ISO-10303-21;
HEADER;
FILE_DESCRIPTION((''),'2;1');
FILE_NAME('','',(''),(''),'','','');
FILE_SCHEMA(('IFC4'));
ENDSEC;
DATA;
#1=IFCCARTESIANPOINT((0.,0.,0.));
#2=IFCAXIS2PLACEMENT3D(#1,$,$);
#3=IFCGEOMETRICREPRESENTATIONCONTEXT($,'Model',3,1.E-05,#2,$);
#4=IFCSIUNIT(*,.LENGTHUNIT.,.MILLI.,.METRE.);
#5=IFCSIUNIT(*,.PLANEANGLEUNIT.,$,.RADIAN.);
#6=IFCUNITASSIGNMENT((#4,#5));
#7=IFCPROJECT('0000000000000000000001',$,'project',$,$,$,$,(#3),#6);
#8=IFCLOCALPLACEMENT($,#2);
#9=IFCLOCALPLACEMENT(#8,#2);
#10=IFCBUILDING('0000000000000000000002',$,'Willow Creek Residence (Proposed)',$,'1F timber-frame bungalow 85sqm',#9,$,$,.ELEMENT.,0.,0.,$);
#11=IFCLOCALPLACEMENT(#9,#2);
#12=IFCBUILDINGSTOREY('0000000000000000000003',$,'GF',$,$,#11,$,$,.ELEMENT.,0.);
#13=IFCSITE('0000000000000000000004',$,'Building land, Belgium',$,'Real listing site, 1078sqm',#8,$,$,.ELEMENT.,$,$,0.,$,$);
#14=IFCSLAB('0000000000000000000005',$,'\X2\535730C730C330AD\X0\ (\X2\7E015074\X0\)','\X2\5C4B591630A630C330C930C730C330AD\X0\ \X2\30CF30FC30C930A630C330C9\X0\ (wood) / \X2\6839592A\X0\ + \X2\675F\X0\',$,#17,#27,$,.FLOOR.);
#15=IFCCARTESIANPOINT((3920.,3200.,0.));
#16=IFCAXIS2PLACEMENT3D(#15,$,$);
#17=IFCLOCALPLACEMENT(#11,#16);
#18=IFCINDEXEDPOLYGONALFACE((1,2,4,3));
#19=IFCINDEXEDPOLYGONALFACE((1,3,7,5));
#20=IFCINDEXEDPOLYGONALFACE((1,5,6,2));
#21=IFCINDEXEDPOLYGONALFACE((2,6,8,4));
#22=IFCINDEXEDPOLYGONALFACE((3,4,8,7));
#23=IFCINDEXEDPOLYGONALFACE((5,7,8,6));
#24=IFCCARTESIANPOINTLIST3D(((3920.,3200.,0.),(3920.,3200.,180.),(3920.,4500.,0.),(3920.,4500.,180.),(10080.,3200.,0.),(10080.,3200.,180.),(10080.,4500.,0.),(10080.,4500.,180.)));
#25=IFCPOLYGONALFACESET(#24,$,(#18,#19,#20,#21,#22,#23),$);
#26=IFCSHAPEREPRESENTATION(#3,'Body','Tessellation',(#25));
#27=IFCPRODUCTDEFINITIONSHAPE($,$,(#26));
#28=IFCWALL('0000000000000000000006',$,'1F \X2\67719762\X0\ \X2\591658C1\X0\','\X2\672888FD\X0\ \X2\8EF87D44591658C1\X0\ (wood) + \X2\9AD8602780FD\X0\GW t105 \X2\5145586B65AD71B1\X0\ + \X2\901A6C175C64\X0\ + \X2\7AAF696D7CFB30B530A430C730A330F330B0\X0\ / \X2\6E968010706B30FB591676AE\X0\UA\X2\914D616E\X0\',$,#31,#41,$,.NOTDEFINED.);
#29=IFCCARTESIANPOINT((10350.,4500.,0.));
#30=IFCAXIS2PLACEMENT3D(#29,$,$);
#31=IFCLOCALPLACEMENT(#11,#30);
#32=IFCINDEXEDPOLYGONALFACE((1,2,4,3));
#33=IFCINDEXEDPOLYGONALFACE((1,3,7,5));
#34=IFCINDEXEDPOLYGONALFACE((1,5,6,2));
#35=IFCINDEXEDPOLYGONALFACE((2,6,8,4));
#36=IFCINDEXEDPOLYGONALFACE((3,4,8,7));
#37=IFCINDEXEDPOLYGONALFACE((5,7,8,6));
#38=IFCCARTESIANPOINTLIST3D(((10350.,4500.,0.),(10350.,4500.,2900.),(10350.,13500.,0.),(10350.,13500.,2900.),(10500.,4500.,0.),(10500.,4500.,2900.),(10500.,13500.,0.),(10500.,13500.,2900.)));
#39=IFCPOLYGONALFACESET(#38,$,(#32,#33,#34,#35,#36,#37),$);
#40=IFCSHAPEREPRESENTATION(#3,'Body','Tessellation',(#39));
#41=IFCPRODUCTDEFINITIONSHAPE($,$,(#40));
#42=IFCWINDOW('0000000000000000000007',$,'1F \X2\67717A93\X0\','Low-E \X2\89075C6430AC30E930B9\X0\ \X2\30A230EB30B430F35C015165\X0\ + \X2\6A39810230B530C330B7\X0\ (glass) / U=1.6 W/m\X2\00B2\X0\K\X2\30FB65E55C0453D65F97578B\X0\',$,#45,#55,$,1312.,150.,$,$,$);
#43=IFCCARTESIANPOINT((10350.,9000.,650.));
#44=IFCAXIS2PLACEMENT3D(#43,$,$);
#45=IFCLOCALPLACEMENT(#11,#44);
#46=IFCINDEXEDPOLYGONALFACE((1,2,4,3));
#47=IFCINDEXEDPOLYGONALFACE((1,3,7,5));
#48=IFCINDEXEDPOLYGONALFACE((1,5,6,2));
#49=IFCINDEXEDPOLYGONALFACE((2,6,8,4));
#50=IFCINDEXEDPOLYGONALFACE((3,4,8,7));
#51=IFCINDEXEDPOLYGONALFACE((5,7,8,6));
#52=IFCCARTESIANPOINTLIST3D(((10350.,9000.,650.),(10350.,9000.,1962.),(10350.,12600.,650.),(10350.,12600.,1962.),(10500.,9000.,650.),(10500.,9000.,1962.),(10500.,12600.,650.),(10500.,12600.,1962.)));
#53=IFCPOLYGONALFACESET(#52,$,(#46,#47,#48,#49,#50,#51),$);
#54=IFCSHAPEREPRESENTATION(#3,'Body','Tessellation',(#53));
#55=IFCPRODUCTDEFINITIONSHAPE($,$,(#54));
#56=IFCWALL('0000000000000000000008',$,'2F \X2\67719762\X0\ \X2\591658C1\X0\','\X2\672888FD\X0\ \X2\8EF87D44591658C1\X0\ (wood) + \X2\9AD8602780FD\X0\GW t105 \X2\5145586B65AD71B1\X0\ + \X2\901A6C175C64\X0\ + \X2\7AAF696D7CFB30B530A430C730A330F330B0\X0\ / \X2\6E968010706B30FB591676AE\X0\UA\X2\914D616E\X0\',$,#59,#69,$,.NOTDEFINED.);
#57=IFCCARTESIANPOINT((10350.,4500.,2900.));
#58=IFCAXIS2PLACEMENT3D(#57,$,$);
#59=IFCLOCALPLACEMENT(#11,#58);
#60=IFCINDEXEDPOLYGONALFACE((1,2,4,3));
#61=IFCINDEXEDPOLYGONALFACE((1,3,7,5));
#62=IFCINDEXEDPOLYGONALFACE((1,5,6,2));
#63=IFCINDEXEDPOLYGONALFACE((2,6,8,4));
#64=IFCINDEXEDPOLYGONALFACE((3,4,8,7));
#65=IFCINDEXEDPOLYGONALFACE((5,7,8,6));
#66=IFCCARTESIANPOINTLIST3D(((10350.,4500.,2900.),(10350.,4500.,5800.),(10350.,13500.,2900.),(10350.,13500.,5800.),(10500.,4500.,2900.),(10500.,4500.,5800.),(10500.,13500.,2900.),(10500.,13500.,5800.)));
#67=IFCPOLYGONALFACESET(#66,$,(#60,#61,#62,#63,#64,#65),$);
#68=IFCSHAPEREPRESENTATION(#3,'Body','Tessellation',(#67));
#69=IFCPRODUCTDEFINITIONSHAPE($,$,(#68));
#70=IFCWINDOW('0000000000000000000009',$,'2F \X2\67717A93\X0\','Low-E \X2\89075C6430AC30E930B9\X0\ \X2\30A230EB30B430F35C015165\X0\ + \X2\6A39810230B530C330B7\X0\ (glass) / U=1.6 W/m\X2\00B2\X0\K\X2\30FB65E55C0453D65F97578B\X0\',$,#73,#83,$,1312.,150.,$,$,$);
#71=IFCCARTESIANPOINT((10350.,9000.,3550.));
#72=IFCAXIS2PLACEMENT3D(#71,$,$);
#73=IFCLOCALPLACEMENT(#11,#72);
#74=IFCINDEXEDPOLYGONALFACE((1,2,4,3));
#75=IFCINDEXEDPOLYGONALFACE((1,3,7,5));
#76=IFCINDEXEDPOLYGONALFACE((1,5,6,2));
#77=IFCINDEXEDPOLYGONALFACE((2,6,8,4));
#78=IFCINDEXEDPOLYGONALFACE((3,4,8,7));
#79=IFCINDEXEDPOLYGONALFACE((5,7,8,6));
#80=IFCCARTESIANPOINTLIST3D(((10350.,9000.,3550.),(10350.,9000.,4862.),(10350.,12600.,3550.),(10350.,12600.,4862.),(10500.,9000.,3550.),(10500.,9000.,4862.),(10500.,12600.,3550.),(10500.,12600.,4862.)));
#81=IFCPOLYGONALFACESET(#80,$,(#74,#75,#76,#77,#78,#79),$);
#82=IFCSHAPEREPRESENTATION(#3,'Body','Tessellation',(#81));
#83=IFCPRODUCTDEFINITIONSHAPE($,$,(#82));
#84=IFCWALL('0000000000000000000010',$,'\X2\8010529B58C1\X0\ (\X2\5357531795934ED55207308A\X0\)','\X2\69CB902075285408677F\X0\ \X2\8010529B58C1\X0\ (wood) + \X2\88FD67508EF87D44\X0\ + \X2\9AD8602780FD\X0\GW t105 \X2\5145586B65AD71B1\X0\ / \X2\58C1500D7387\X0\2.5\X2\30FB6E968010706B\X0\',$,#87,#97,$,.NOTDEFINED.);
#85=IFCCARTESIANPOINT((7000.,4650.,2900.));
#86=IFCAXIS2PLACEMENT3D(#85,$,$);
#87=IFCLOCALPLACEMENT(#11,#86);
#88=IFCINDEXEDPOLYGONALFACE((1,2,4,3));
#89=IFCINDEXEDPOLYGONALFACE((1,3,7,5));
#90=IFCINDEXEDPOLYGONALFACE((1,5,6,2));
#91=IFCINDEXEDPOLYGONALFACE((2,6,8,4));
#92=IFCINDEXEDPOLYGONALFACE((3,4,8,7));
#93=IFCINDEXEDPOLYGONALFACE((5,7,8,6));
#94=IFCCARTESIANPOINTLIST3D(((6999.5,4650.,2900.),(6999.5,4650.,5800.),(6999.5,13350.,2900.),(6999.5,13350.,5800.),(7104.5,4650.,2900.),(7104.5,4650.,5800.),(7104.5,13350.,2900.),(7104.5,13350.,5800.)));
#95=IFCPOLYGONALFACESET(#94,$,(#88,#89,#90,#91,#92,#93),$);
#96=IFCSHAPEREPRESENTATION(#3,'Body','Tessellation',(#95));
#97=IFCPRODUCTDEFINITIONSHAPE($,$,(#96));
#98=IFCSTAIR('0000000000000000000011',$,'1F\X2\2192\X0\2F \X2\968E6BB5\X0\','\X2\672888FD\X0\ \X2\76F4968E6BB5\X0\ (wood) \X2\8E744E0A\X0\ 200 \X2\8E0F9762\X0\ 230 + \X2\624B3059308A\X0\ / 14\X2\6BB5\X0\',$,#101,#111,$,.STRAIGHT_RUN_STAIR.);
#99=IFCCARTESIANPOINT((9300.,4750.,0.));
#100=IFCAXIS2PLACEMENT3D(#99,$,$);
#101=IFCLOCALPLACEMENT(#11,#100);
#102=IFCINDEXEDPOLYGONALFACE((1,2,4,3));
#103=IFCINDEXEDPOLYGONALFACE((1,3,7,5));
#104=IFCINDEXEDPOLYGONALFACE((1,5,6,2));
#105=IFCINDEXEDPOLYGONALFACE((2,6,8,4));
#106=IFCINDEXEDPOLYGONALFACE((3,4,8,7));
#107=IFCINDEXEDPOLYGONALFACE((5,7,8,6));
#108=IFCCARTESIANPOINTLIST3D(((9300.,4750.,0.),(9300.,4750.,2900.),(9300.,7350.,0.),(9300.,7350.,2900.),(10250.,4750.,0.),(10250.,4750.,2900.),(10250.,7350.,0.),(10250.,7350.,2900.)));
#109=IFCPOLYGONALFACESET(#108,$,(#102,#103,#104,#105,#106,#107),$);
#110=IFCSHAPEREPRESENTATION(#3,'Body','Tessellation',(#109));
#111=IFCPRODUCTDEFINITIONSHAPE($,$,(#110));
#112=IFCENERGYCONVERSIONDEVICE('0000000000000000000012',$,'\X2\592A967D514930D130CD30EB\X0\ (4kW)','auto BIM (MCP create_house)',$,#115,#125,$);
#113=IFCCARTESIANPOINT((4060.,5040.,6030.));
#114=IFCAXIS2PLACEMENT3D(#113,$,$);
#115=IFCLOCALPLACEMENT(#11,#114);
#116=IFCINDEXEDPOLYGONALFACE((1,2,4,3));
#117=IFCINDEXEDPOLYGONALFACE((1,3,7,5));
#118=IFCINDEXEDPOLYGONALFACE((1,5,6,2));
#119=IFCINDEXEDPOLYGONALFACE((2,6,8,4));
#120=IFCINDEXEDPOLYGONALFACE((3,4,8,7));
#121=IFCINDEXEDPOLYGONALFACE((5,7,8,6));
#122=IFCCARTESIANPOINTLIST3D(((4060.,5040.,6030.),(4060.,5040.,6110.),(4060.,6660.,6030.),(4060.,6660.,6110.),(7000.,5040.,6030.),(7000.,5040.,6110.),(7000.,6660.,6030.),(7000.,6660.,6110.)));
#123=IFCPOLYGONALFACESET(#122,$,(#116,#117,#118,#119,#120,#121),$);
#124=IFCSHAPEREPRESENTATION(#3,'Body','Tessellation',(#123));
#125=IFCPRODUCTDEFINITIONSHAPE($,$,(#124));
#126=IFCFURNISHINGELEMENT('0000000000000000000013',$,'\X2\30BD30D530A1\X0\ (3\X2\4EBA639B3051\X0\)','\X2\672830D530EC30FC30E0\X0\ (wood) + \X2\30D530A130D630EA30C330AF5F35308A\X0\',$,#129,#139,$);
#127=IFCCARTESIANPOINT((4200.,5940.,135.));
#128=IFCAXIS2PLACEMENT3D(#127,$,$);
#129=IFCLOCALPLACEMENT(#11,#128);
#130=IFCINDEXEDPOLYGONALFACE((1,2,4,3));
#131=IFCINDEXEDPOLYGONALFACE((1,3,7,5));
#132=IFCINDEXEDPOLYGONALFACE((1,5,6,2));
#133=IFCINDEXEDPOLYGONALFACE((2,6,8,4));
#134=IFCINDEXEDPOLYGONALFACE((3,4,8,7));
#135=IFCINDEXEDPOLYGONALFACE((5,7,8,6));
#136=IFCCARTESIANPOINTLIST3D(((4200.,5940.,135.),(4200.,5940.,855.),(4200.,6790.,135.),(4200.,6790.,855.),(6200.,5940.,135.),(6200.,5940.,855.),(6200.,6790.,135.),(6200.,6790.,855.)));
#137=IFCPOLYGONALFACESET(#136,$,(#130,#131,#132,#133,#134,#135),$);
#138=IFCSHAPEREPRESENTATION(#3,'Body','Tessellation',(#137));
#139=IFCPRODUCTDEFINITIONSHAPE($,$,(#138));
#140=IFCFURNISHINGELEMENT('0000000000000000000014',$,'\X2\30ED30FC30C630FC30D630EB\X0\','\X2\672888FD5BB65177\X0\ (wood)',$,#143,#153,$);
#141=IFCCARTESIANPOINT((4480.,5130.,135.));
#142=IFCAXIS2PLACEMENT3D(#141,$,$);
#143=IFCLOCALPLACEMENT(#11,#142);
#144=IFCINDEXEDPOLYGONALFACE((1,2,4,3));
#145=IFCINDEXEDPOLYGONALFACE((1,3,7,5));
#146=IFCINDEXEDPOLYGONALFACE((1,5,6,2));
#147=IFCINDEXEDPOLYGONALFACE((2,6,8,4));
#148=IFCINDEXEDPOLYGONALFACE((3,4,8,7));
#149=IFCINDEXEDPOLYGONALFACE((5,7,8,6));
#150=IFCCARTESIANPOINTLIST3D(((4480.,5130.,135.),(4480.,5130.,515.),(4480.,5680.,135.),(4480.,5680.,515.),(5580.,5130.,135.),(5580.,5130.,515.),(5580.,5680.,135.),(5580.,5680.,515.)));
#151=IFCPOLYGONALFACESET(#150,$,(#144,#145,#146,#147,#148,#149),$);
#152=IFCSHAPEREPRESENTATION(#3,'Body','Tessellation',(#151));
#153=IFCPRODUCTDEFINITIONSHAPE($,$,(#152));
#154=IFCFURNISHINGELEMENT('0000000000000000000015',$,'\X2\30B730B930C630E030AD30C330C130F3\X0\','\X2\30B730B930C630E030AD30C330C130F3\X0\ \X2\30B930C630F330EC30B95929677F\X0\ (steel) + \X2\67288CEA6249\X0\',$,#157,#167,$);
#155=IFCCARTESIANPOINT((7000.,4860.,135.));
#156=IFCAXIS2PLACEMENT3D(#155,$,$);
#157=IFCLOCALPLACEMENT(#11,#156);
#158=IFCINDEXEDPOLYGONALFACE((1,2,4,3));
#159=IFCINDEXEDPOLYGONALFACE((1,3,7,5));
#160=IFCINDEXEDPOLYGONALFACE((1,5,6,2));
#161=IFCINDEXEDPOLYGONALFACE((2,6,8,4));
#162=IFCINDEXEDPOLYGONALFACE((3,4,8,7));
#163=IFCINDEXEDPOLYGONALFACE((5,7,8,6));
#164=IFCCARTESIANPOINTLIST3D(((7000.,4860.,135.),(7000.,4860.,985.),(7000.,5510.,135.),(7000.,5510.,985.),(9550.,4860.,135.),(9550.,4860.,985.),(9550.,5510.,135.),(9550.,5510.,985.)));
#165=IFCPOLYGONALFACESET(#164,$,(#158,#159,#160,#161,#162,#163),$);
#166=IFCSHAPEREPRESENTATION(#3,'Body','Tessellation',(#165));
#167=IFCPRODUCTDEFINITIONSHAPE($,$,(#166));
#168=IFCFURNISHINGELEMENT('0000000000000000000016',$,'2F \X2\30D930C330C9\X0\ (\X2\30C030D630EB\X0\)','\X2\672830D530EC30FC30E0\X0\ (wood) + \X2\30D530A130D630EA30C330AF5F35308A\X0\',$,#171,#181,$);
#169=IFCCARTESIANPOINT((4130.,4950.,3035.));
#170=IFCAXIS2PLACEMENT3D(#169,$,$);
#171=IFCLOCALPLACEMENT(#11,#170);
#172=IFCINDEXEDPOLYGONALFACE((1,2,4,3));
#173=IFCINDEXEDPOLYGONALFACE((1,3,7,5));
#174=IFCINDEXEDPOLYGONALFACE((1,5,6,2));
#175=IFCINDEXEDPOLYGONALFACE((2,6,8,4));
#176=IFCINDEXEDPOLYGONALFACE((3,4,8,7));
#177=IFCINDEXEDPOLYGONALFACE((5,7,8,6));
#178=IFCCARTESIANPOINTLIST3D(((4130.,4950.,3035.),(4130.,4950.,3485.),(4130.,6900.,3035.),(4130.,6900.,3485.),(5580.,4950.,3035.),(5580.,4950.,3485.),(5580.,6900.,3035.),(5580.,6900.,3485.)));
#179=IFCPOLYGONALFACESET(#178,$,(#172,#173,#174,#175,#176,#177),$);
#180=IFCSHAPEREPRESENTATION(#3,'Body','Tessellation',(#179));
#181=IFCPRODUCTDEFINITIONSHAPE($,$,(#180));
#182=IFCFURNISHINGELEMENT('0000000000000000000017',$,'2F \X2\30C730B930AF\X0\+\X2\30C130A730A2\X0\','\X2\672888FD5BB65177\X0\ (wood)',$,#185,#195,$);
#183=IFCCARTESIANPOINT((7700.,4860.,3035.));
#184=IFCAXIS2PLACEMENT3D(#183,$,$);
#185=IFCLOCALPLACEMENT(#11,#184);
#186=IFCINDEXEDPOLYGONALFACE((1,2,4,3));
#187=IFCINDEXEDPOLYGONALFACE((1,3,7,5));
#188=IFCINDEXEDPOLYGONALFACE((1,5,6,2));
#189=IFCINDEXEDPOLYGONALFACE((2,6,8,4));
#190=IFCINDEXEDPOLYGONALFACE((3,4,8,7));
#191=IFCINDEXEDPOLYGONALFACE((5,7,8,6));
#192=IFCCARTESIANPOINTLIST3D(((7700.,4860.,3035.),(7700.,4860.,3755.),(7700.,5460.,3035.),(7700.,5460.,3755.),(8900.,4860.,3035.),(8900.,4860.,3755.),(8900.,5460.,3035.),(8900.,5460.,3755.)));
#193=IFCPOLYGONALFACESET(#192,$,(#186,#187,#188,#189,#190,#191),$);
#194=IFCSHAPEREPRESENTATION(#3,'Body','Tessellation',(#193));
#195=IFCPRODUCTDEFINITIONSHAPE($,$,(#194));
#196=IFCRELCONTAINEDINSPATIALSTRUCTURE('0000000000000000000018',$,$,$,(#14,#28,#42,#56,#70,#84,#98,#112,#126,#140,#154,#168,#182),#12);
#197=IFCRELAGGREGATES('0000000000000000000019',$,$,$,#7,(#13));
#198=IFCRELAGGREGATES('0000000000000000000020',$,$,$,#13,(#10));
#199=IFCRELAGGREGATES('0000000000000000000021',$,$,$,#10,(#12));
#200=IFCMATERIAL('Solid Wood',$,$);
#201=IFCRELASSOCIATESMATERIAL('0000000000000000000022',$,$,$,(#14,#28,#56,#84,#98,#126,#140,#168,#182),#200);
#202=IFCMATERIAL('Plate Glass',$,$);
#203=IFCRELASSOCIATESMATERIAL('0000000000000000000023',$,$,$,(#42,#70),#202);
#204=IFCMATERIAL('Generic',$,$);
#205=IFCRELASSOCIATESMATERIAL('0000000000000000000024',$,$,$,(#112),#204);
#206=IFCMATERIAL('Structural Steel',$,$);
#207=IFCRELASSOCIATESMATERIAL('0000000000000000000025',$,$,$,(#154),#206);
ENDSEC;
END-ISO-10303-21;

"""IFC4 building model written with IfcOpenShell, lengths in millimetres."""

from ifc_helpers import new_model, si_unit, frame, frame_2d, origin, place, context, project, spatial, rectangle, extrude, material, element, fill, save


model = new_model("IFC4")

# Units and contexts
model_context = context("Model", 3, precision=1e-05, world=origin())
ifc_project = project(units=[si_unit("LENGTHUNIT", "METRE", prefix="MILLI"), si_unit("PLANEANGLEUNIT", "RADIAN")], contexts=[model_context])

# Site, building, storey
site_placement = place(None, origin())
site = spatial("IfcSite", under=ifc_project, at=site_placement, Name="Building land, Belgium", ObjectType="Real listing site, 1078sqm", CompositionType="ELEMENT", RefElevation=0.0)
building_placement = place(site_placement, origin())
building = spatial("IfcBuilding", under=site, at=building_placement, Name="Willow Creek Residence (Proposed)", ObjectType="1F timber-frame bungalow 85sqm", CompositionType="ELEMENT", ElevationOfRefHeight=0.0, ElevationOfTerrain=0.0)
storey_placement = place(building_placement, origin())
storey = spatial("IfcBuildingStorey", under=building, at=storey_placement, Name="GF", CompositionType="ELEMENT", Elevation=0.0)

# Slab
ifc_material_1 = material(Name="Solid Wood")
slab_placement = place(storey_placement, frame((3920.0, 3200.0, 0.0)))
element("IfcSlab", 1, at=slab_placement, inside=storey, material=ifc_material_1, Name="南デッキ (縁側)", Description="屋外ウッドデッキ ハードウッド (wood) / 根太 + 束", PredefinedType="FLOOR", context=model_context, shape_type="SweptSolid", body=[
    extrude(rectangle(XDim=6160.0, YDim=1300.0, at=frame_2d((3080.0, 650.0))), frame((3920.0, 3200.0, 0.0)), (0.0, 0.0, 1.0), 180.0),
])

# Wall, opening, window
wall_1_placement = place(storey_placement, frame((10350.0, 4500.0, 0.0)))
wall_1 = element("IfcWall", 2, at=wall_1_placement, inside=storey, material=ifc_material_1, Name="1F 東面 外壁", Description="木製 軸組外壁 (wood) + 高性能GW t105 充填断熱 + 通気層 + 窯業系サイディング / 準耐火・外皮UA配慮", PredefinedType="NOTDEFINED", context=model_context, shape_type="SweptSolid", body=[
    extrude(rectangle(XDim=150.0, YDim=9000.0, at=frame_2d((75.0, 4500.0))), frame((10350.0, 4500.0, 0.0)), (0.0, 0.0, 1.0), 2900.0),
])
opening_1_placement = place(storey_placement, frame((10350.0, 9000.0, 650.0)))
opening_1 = element("IfcOpeningElement", 3, at=opening_1_placement, cuts=wall_1, PredefinedType="NOTDEFINED", context=model_context, shape_type="SweptSolid", body=[
    extrude(rectangle(XDim=150.0, YDim=3600.0, at=frame_2d((75.0, 1800.0))), frame((10350.0, 9000.0, 650.0)), (0.0, 0.0, 1.0), 1312.0),
])
ifc_material_2 = material(Name="Plate Glass")
window_1_placement = place(storey_placement, frame((10350.0, 9000.0, 650.0)))
window_1 = element("IfcWindow", 4, at=window_1_placement, inside=storey, material=ifc_material_2, Name="1F 東窓", Description="Low-E 複層ガラス アルゴン封入 + 樹脂サッシ (glass) / U=1.6 W/m²K・日射取得型", OverallHeight=1312.0, OverallWidth=150.0, context=model_context, shape_type="SweptSolid", body=[
    extrude(rectangle(XDim=150.0, YDim=3600.0, at=frame_2d((75.0, 1800.0))), frame((10350.0, 9000.0, 650.0)), (0.0, 0.0, 1.0), 1312.0),
])
fill(opening_1, window_1)

# Wall, opening, window
wall_2_placement = place(storey_placement, frame((10350.0, 4500.0, 2900.0)))
wall_2 = element("IfcWall", 5, at=wall_2_placement, inside=storey, material=ifc_material_1, Name="2F 東面 外壁", Description="木製 軸組外壁 (wood) + 高性能GW t105 充填断熱 + 通気層 + 窯業系サイディング / 準耐火・外皮UA配慮", PredefinedType="NOTDEFINED", context=model_context, shape_type="SweptSolid", body=[
    extrude(rectangle(XDim=150.0, YDim=9000.0, at=frame_2d((75.0, 4500.0))), frame((10350.0, 4500.0, 2900.0)), (0.0, 0.0, 1.0), 2900.0),
])
opening_2_placement = place(storey_placement, frame((10350.0, 9000.0, 3550.0)))
opening_2 = element("IfcOpeningElement", 6, at=opening_2_placement, cuts=wall_2, PredefinedType="NOTDEFINED", context=model_context, shape_type="SweptSolid", body=[
    extrude(rectangle(XDim=150.0, YDim=3600.0, at=frame_2d((75.0, 1800.0))), frame((10350.0, 9000.0, 3550.0)), (0.0, 0.0, 1.0), 1312.0),
])
window_2_placement = place(storey_placement, frame((10350.0, 9000.0, 3550.0)))
window_2 = element("IfcWindow", 7, at=window_2_placement, inside=storey, material=ifc_material_2, Name="2F 東窓", Description="Low-E 複層ガラス アルゴン封入 + 樹脂サッシ (glass) / U=1.6 W/m²K・日射取得型", OverallHeight=1312.0, OverallWidth=150.0, context=model_context, shape_type="SweptSolid", body=[
    extrude(rectangle(XDim=150.0, YDim=3600.0, at=frame_2d((75.0, 1800.0))), frame((10350.0, 9000.0, 3550.0)), (0.0, 0.0, 1.0), 1312.0),
])
fill(opening_2, window_2)

# Wall
wall_3_placement = place(storey_placement, frame((7000.0, 4650.0, 2900.0)))
element("IfcWall", 8, at=wall_3_placement, inside=storey, material=ifc_material_1, Name="耐力壁 (南北間仕切り)", Description="構造用合板 耐力壁 (wood) + 製材軸組 + 高性能GW t105 充填断熱 / 壁倍率2.5・準耐火", PredefinedType="NOTDEFINED", context=model_context, shape_type="SweptSolid", body=[
    extrude(rectangle(XDim=105.0, YDim=8700.0, at=frame_2d((52.0, 4350.0))), frame((7000.0, 4650.0, 2900.0)), (0.0, 0.0, 1.0), 2900.0),
])

# Stair
stair_placement = place(storey_placement, frame((9300.0, 4750.0, 0.0)))
element("IfcStair", 9, at=stair_placement, inside=storey, material=ifc_material_1, Name="1F→2F 階段", Description="木製 直階段 (wood) 蹴上 200 踏面 230 + 手すり / 14段", PredefinedType="STRAIGHT_RUN_STAIR", context=model_context, shape_type="SweptSolid", body=[
    extrude(rectangle(XDim=950.0, YDim=2600.0, at=frame_2d((475.0, 1300.0))), frame((9300.0, 4750.0, 0.0)), (0.0, 0.0, 1.0), 2900.0),
])

# Energy conversion device
ifc_material_3 = material(Name="Generic")
energy_conversion_device_placement = place(storey_placement, frame((4060.0, 5040.0, 6030.0)))
element("IfcEnergyConversionDevice", 10, at=energy_conversion_device_placement, inside=storey, material=ifc_material_3, Name="太陽光パネル (4kW)", Description="auto BIM (MCP create_house)", context=model_context, shape_type="SweptSolid", body=[
    extrude(rectangle(XDim=2940.0, YDim=1620.0, at=frame_2d((1470.0, 810.0))), frame((4060.0, 5040.0, 6030.0)), (0.0, 0.0, 1.0), 80.0),
])

# Furnishing elements
furnishing_1_placement = place(storey_placement, frame((4200.0, 5940.0, 135.0)))
element("IfcFurnishingElement", 11, at=furnishing_1_placement, inside=storey, material=ifc_material_1, Name="ソファ (3人掛け)", Description="木フレーム (wood) + ファブリック張り", context=model_context, shape_type="SweptSolid", body=[
    extrude(rectangle(XDim=2000.0, YDim=850.0, at=frame_2d((1000.0, 425.0))), frame((4200.0, 5940.0, 135.0)), (0.0, 0.0, 1.0), 720.0),
])
furnishing_2_placement = place(storey_placement, frame((4480.0, 5130.0, 135.0)))
element("IfcFurnishingElement", 12, at=furnishing_2_placement, inside=storey, material=ifc_material_1, Name="ローテーブル", Description="木製家具 (wood)", context=model_context, shape_type="SweptSolid", body=[
    extrude(rectangle(XDim=1100.0, YDim=550.0, at=frame_2d((550.0, 275.0))), frame((4480.0, 5130.0, 135.0)), (0.0, 0.0, 1.0), 380.0),
])
ifc_material_4 = material(Name="Structural Steel")
furnishing_3_placement = place(storey_placement, frame((7000.0, 4860.0, 135.0)))
element("IfcFurnishingElement", 13, at=furnishing_3_placement, inside=storey, material=ifc_material_4, Name="システムキッチン", Description="システムキッチン ステンレス天板 (steel) + 木質扉", context=model_context, shape_type="SweptSolid", body=[
    extrude(rectangle(XDim=2550.0, YDim=650.0, at=frame_2d((1275.0, 325.0))), frame((7000.0, 4860.0, 135.0)), (0.0, 0.0, 1.0), 850.0),
])
furnishing_4_placement = place(storey_placement, frame((4130.0, 4950.0, 3035.0)))
element("IfcFurnishingElement", 14, at=furnishing_4_placement, inside=storey, material=ifc_material_1, Name="2F ベッド (ダブル)", Description="木フレーム (wood) + ファブリック張り", context=model_context, shape_type="SweptSolid", body=[
    extrude(rectangle(XDim=1450.0, YDim=1950.0, at=frame_2d((725.0, 975.0))), frame((4130.0, 4950.0, 3035.0)), (0.0, 0.0, 1.0), 450.0),
])
furnishing_5_placement = place(storey_placement, frame((7700.0, 4860.0, 3035.0)))
element("IfcFurnishingElement", 15, at=furnishing_5_placement, inside=storey, material=ifc_material_1, Name="2F デスク+チェア", Description="木製家具 (wood)", context=model_context, shape_type="SweptSolid", body=[
    extrude(rectangle(XDim=1200.0, YDim=600.0, at=frame_2d((600.0, 300.0))), frame((7700.0, 4860.0, 3035.0)), (0.0, 0.0, 1.0), 720.0),
])

save(model, "model.ifc")
